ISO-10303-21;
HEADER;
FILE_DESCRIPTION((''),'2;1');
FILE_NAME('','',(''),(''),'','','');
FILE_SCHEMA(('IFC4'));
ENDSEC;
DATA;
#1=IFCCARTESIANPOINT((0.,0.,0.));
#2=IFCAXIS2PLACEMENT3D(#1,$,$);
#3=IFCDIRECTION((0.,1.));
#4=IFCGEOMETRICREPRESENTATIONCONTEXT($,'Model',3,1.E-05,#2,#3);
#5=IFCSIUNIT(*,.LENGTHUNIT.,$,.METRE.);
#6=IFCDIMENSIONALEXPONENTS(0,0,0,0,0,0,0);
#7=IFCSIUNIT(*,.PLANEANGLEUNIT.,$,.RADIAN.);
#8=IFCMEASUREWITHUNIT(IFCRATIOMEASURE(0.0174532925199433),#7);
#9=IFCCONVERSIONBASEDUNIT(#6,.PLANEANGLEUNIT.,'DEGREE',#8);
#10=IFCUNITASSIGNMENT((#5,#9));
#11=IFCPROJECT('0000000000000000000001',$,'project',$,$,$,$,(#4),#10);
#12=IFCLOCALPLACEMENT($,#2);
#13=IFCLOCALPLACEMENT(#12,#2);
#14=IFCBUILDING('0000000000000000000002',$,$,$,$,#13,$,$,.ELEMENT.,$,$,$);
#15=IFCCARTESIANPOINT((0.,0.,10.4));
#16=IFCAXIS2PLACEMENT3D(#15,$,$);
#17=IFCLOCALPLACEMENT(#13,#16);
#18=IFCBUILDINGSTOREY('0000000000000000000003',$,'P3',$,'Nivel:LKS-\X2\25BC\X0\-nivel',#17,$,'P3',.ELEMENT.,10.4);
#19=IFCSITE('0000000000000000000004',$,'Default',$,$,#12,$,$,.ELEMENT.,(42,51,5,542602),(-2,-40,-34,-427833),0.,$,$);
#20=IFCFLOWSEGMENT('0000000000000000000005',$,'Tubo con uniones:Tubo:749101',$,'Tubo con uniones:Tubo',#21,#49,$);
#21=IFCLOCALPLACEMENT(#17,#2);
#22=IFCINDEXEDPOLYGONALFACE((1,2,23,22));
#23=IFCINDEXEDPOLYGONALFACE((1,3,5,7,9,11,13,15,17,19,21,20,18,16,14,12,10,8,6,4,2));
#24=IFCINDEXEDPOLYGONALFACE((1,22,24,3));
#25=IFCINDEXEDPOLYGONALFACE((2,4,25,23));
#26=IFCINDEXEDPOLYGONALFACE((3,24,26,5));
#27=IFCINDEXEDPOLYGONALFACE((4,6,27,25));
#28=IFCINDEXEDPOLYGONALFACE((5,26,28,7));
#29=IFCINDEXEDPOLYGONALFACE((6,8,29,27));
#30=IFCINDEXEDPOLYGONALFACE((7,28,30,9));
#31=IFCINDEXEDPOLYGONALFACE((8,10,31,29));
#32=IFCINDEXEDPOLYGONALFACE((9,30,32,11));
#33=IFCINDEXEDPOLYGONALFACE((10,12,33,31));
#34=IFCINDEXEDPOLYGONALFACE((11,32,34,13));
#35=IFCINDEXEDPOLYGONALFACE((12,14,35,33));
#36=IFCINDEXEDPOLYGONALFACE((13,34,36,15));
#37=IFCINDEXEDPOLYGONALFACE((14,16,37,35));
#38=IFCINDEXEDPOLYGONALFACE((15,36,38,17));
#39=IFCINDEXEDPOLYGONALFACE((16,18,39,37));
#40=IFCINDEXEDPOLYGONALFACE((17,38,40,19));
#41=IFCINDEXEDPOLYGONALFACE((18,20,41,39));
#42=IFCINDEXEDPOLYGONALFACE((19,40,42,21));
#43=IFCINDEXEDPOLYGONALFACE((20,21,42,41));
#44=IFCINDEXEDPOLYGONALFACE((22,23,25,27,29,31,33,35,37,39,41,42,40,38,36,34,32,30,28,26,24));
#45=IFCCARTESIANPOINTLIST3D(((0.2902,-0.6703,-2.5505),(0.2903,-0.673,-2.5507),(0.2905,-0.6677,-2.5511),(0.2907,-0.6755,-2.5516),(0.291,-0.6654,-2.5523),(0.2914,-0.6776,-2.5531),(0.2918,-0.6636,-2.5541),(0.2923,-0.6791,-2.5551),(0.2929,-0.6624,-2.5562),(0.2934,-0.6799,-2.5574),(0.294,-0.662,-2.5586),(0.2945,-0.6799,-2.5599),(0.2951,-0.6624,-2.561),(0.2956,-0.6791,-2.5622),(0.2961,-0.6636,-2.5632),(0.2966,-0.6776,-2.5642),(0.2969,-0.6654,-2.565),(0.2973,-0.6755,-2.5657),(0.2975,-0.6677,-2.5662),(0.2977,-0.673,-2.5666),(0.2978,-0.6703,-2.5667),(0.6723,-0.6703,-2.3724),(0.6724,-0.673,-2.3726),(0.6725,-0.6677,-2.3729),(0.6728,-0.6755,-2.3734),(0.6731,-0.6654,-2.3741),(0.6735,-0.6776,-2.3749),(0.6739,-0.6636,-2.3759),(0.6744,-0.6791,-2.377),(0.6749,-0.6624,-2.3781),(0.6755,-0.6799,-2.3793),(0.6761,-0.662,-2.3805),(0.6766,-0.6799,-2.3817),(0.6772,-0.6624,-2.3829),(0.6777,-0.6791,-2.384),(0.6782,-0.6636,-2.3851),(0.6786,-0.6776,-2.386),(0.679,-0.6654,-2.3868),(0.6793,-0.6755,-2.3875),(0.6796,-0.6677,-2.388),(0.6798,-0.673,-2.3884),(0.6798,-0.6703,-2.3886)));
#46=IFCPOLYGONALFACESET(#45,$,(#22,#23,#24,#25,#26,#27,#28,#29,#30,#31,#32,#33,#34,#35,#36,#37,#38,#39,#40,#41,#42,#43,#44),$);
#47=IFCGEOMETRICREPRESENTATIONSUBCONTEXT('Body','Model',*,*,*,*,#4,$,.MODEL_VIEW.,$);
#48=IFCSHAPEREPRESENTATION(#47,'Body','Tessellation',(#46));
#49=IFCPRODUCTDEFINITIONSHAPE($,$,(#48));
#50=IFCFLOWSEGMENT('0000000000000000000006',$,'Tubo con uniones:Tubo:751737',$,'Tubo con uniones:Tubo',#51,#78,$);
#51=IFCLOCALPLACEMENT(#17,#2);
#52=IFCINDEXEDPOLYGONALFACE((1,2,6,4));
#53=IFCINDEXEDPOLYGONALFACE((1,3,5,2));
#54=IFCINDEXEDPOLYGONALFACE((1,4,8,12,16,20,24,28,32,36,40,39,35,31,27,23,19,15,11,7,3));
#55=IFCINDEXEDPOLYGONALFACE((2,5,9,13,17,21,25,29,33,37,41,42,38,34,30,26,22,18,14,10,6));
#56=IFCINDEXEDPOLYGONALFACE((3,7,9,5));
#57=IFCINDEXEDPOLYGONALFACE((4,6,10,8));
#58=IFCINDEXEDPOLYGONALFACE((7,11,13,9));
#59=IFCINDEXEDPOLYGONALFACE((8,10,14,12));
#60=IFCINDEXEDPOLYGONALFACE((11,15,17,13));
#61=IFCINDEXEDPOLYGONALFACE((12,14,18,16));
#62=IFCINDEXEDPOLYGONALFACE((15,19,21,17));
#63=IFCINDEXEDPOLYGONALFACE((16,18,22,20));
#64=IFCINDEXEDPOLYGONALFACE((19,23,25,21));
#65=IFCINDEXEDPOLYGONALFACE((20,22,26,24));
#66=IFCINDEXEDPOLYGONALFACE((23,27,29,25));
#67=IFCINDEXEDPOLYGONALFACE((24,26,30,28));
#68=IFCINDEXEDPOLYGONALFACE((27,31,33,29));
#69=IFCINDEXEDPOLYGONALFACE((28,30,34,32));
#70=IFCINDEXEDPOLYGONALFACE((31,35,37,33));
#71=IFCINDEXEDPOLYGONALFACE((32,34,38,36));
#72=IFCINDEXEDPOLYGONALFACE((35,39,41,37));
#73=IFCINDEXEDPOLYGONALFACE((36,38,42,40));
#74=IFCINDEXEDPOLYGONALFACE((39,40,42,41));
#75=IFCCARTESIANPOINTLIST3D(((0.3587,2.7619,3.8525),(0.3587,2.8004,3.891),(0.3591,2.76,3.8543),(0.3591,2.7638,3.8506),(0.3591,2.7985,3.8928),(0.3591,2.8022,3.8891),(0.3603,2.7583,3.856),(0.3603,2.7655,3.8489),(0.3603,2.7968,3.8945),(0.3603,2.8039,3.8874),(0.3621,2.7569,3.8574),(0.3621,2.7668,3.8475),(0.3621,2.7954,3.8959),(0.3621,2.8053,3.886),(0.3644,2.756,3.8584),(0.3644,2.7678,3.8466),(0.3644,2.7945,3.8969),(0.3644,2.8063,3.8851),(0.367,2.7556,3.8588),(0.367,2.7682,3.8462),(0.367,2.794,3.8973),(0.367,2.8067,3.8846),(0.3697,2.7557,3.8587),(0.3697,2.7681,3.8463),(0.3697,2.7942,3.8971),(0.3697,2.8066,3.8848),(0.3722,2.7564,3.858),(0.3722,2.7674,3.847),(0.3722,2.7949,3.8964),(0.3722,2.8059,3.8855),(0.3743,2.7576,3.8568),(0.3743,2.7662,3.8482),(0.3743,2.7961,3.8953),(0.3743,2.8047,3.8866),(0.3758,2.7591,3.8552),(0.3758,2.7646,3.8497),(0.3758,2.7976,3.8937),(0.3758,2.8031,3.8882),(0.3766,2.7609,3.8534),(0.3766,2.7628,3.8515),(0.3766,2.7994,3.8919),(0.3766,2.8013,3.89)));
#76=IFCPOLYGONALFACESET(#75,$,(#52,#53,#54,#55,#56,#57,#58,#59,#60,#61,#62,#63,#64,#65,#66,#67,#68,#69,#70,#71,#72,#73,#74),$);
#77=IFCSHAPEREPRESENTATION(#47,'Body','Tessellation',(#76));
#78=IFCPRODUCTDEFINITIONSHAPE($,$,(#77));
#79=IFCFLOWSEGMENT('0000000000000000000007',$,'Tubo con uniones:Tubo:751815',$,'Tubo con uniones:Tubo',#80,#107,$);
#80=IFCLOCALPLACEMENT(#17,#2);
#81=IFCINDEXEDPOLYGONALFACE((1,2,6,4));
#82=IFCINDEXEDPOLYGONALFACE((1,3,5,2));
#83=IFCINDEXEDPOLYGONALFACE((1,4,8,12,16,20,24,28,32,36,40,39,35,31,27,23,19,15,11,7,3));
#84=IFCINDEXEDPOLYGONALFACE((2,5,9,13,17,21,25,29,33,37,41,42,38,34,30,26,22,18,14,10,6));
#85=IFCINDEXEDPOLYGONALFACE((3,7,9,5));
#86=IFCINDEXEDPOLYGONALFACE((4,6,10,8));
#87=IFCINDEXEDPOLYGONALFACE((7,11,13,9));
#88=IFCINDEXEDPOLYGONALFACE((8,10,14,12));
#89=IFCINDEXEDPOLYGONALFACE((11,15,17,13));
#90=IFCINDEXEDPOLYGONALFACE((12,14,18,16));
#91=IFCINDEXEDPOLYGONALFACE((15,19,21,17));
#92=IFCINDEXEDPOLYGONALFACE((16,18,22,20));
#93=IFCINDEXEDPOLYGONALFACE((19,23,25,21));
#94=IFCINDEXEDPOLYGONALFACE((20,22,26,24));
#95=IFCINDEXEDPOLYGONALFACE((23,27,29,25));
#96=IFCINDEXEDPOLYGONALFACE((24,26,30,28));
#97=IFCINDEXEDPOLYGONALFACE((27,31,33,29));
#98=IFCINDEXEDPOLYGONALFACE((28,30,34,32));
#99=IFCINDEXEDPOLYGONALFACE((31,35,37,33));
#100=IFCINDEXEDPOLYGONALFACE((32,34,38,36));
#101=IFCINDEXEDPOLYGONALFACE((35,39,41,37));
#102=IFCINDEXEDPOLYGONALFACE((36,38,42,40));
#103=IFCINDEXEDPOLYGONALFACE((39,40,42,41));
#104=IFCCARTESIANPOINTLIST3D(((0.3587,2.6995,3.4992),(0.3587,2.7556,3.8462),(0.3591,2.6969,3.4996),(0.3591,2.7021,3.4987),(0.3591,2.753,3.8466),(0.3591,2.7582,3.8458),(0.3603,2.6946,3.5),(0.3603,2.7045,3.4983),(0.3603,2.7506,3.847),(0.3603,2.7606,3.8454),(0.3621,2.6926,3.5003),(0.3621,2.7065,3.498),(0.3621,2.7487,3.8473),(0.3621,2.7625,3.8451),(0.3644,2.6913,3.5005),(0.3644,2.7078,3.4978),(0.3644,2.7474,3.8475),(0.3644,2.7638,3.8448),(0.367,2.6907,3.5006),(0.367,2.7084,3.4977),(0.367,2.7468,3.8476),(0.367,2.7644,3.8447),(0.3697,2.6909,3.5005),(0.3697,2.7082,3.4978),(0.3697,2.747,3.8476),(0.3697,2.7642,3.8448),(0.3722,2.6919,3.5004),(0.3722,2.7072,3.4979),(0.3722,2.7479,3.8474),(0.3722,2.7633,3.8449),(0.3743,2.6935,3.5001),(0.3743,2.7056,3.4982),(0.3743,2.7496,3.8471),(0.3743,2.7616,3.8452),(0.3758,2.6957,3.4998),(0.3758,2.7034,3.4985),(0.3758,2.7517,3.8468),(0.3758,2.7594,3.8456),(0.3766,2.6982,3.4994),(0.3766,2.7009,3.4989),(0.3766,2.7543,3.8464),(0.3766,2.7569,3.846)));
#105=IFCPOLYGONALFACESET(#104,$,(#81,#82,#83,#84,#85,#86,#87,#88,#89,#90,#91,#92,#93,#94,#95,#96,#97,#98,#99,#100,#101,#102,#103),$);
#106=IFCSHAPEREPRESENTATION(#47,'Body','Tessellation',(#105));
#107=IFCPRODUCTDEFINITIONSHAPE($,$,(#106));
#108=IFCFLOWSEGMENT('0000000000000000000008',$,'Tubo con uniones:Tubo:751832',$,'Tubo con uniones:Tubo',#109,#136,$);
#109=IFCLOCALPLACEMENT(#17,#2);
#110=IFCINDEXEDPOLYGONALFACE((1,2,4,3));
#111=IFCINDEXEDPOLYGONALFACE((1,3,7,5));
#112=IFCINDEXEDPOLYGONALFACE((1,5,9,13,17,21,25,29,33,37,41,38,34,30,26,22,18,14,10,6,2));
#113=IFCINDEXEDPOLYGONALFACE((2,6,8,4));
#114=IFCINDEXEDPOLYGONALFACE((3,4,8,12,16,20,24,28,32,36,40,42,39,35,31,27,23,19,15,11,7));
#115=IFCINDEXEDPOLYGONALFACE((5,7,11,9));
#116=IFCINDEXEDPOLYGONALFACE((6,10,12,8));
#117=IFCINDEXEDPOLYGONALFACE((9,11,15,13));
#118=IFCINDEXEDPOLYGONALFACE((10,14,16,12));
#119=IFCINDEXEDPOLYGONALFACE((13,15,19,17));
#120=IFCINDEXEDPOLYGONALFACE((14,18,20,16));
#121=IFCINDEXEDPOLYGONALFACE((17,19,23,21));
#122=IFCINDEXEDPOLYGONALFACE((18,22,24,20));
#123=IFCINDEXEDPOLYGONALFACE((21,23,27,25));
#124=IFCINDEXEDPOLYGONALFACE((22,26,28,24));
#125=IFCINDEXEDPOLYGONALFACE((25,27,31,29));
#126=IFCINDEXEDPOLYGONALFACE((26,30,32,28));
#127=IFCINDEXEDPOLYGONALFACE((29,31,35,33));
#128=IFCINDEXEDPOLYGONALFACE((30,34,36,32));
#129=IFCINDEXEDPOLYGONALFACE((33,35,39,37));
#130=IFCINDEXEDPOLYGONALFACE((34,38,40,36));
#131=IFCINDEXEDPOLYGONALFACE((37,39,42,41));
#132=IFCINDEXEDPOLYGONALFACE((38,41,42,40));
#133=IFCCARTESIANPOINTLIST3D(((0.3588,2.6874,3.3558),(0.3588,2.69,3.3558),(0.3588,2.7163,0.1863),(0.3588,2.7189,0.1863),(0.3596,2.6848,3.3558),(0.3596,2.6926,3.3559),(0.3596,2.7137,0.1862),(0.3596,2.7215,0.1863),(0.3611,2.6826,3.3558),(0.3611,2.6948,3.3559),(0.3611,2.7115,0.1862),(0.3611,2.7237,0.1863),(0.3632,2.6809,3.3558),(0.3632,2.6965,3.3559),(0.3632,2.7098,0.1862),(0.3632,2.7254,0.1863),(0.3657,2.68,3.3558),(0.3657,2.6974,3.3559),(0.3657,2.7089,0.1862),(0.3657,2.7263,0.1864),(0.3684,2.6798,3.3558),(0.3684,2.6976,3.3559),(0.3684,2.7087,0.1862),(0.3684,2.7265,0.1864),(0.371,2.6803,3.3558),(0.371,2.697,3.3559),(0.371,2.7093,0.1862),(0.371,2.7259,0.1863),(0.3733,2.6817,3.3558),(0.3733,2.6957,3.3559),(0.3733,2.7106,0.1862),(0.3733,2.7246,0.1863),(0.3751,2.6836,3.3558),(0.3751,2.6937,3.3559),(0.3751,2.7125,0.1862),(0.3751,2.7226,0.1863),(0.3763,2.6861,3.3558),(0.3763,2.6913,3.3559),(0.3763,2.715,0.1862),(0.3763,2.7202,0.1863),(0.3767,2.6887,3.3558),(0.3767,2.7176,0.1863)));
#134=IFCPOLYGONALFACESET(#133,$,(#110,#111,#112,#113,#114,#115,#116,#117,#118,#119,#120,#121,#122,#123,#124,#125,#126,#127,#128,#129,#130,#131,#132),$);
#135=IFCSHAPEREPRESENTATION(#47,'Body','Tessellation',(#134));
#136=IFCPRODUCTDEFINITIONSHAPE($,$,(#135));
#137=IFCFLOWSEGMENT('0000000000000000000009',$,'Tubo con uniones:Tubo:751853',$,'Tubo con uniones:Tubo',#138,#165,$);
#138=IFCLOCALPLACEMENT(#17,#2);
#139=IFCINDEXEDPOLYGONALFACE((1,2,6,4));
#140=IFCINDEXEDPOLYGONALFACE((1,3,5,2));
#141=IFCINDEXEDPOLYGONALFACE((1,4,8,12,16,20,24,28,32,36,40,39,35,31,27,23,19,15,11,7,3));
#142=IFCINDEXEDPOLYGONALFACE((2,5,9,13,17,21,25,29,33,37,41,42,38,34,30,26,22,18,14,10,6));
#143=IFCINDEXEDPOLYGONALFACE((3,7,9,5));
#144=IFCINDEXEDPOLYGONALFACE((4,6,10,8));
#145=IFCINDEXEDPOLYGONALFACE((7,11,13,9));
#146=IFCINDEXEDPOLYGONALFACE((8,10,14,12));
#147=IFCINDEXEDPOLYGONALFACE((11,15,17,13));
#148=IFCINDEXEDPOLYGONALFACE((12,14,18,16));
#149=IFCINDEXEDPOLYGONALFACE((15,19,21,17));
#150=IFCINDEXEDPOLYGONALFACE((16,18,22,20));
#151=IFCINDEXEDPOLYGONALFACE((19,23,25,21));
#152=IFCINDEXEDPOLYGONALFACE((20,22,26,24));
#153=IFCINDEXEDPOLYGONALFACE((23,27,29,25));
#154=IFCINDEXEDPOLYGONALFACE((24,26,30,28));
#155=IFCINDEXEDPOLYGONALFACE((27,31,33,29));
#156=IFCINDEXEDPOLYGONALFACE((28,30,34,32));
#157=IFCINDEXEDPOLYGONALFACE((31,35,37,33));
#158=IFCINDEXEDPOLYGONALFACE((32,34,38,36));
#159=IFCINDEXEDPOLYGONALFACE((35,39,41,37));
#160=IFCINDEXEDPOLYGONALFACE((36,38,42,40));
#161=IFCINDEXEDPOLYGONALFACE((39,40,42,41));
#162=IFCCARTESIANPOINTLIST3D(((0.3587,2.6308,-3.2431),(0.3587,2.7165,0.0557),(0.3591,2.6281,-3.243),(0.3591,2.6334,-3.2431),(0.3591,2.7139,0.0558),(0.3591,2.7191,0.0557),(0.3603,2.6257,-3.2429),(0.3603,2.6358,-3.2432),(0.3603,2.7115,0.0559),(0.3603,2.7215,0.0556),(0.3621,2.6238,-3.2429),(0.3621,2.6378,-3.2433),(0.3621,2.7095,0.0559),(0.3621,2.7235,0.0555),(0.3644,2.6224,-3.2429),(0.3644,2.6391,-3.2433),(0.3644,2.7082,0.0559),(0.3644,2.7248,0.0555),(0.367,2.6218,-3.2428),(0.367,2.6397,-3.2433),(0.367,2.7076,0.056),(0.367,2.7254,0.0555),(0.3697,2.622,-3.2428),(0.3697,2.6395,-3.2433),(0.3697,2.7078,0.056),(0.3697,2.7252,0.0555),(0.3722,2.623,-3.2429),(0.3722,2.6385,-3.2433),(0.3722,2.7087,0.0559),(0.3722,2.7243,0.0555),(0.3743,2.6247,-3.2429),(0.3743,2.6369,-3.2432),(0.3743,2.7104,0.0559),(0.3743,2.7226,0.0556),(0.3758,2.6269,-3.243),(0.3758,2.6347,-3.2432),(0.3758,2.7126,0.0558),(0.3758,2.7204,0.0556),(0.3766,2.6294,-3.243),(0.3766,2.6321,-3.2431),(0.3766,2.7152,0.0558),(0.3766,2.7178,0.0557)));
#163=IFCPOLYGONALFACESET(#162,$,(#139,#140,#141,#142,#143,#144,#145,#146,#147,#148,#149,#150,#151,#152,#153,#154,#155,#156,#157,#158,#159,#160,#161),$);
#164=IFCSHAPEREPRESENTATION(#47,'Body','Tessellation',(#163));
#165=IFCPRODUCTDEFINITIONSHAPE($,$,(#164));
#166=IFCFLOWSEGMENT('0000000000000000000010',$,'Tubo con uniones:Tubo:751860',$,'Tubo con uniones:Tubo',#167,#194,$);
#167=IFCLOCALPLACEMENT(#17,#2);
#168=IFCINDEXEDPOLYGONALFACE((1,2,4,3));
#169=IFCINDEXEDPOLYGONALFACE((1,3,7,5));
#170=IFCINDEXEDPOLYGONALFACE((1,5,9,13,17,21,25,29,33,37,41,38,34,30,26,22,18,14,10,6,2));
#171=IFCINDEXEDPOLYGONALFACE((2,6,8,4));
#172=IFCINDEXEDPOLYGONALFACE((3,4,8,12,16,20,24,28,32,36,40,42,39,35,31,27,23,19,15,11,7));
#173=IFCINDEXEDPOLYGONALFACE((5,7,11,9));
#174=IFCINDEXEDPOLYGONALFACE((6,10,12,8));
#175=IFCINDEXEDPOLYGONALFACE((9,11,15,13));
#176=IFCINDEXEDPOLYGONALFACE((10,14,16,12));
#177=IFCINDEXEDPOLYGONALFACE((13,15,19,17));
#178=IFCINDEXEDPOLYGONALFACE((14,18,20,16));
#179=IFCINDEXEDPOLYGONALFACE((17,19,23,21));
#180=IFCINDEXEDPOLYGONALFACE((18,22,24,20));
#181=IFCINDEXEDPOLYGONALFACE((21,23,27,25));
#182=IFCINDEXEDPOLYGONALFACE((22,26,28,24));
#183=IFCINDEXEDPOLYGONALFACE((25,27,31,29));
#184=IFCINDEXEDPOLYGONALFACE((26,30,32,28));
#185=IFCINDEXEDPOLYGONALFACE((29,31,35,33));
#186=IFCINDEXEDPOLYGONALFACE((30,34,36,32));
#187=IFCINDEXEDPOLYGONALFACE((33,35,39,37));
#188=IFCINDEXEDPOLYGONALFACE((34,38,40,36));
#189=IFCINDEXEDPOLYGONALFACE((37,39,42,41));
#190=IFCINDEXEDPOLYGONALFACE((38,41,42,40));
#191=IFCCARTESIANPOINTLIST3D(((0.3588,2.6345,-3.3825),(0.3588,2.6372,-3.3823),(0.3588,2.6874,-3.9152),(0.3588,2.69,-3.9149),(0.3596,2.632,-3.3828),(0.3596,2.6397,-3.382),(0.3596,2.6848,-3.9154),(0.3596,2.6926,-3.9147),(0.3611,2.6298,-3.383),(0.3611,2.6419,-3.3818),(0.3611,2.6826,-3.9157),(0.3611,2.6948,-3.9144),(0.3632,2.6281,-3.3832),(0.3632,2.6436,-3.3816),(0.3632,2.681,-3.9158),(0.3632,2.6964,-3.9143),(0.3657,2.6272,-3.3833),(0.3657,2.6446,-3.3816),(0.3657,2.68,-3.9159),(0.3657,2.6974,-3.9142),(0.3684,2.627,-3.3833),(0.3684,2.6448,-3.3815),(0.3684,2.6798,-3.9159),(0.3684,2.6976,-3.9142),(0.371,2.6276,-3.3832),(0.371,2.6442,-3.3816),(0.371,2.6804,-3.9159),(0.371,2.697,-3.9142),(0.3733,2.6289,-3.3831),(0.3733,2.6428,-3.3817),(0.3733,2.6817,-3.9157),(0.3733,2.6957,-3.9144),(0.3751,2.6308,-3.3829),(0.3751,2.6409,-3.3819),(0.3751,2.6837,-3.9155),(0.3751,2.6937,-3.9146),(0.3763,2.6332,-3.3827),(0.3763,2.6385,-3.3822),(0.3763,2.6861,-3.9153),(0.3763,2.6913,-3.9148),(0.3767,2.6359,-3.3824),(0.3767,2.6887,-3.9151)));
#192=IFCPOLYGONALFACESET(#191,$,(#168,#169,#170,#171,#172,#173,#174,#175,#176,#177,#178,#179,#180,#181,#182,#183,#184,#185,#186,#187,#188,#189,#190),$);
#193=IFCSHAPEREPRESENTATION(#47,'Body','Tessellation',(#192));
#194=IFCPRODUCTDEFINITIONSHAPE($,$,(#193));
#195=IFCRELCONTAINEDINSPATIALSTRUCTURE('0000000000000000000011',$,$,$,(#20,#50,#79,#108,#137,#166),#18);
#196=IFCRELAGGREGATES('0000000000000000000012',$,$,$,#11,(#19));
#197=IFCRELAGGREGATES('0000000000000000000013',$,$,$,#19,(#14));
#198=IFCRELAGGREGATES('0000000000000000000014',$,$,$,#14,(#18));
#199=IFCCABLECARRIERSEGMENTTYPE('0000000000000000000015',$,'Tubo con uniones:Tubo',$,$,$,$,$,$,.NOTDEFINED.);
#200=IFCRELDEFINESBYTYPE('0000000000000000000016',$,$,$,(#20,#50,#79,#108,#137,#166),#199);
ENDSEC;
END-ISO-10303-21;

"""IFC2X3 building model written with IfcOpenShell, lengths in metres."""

from ifc_helpers import new_model, entity, si_unit, converted_unit, direction, frame, frame_2d, origin, place, context, subcontext, project, spatial, circle, extrude, type_object, element, save


model = new_model("IFC2X3")

# Units and contexts
model_context = context("Model", 3, precision=1e-05, world=origin(), true_north=direction((0.0, 1.0)))
body_context = subcontext(model_context, "Body", "Model", "MODEL_VIEW")
ifc_project = project(units=[si_unit("LENGTHUNIT", "METRE"), converted_unit("PLANEANGLEUNIT", "DEGREE", entity("IfcRatioMeasure", 0.0174532925199433), si_unit("PLANEANGLEUNIT", "RADIAN"), dimensions=[0, 0, 0, 0, 0, 0, 0])], contexts=[model_context])

# Site, building, storey
site_placement = place(None, origin())
site = spatial("IfcSite", under=ifc_project, at=site_placement, Name="Default", CompositionType="ELEMENT", RefLatitude=(42, 51, 5, 542602), RefLongitude=(-2, -40, -34, -427833), RefElevation=0.0)
building_placement = place(site_placement, origin())
building = spatial("IfcBuilding", under=site, at=building_placement, CompositionType="ELEMENT")
storey_placement = place(building_placement, frame((0.0, 0.0, 10.4)))
storey = spatial("IfcBuildingStorey", under=building, at=storey_placement, Name="P3", ObjectType="Nivel:LKS-▼-nivel", LongName="P3", CompositionType="ELEMENT", Elevation=10.4)

# Flow segments
cable_carrier_segment_type = type_object("IfcCableCarrierSegmentType", Name="Tubo con uniones:Tubo", PredefinedType="NOTDEFINED")
flow_segment_1_placement = place(storey_placement, origin())
element("IfcFlowSegment", 1, at=flow_segment_1_placement, inside=storey, type_object=cable_carrier_segment_type, Name="Tubo con uniones:Tubo:749101", ObjectType="Tubo con uniones:Tubo", context=body_context, shape_type="SweptSolid", body=[
    extrude(circle(Radius=0.009, at=frame_2d((0.0, 0.0), x_axis=(1.0, 0.0))), frame((0.294, -0.671, -2.5586), z_axis=(0.906308, 0.0, 0.422618), x_axis=(0.0, 1.0, 0.0)), (0.0, 0.0, 1.0), 0.4216),
])
flow_segment_2_placement = place(storey_placement, origin())
element("IfcFlowSegment", 2, at=flow_segment_2_placement, inside=storey, type_object=cable_carrier_segment_type, Name="Tubo con uniones:Tubo:751737", ObjectType="Tubo con uniones:Tubo", context=body_context, shape_type="SweptSolid", body=[
    extrude(circle(Radius=0.009, at=frame_2d((0.0, 0.0), x_axis=(1.0, 0.0))), frame((0.3677, 2.7619, 3.8525), z_axis=(0.0, 0.707107, 0.707107), x_axis=(-1.0, 0.0, 0.0)), (0.0, 0.0, 1.0), 0.0544),
])
flow_segment_3_placement = place(storey_placement, origin())
element("IfcFlowSegment", 3, at=flow_segment_3_placement, inside=storey, type_object=cable_carrier_segment_type, Name="Tubo con uniones:Tubo:751815", ObjectType="Tubo con uniones:Tubo", context=body_context, shape_type="SweptSolid", body=[
    extrude(circle(Radius=0.009, at=frame_2d((0.0, 0.0), x_axis=(1.0, 0.0))), frame((0.3677, 2.6995, 3.4992), z_axis=(0.0, 0.15946, 0.987204), x_axis=(-1.0, 0.0, 0.0)), (0.0, 0.0, 1.0), 0.3515),
])
flow_segment_4_placement = place(storey_placement, origin())
element("IfcFlowSegment", 4, at=flow_segment_4_placement, inside=storey, type_object=cable_carrier_segment_type, Name="Tubo con uniones:Tubo:751832", ObjectType="Tubo con uniones:Tubo", context=body_context, shape_type="SweptSolid", body=[
    extrude(circle(Radius=0.009, at=frame_2d((0.0, 0.0), x_axis=(1.0, 0.0))), frame((0.3677, 2.6887, 3.3558), z_axis=(0.0, 0.00912, -0.999958), x_axis=(1.0, 0.0, 0.0)), (0.0, 0.0, 1.0), 3.1697),
])
flow_segment_5_placement = place(storey_placement, origin())
element("IfcFlowSegment", 5, at=flow_segment_5_placement, inside=storey, type_object=cable_carrier_segment_type, Name="Tubo con uniones:Tubo:751853", ObjectType="Tubo con uniones:Tubo", context=body_context, shape_type="SweptSolid", body=[
    extrude(circle(Radius=0.009, at=frame_2d((0.0, 0.0), x_axis=(1.0, 0.0))), frame((0.3677, 2.6308, -3.2431), z_axis=(0.0, 0.025977, 0.999663), x_axis=(-1.0, 0.0, 0.0)), (0.0, 0.0, 1.0), 3.2999),
])
flow_segment_6_placement = place(storey_placement, origin())
element("IfcFlowSegment", 6, at=flow_segment_6_placement, inside=storey, type_object=cable_carrier_segment_type, Name="Tubo con uniones:Tubo:751860", ObjectType="Tubo con uniones:Tubo", context=body_context, shape_type="SweptSolid", body=[
    extrude(circle(Radius=0.009, at=frame_2d((0.0, 0.0), x_axis=(1.0, 0.0))), frame((0.3677, 2.6887, -3.9151), z_axis=(0.0, -0.098722, 0.995115), x_axis=(1.0, 0.0, 0.0)), (0.0, 0.0, 1.0), 0.5353),
])

save(model, "model.ifc")
